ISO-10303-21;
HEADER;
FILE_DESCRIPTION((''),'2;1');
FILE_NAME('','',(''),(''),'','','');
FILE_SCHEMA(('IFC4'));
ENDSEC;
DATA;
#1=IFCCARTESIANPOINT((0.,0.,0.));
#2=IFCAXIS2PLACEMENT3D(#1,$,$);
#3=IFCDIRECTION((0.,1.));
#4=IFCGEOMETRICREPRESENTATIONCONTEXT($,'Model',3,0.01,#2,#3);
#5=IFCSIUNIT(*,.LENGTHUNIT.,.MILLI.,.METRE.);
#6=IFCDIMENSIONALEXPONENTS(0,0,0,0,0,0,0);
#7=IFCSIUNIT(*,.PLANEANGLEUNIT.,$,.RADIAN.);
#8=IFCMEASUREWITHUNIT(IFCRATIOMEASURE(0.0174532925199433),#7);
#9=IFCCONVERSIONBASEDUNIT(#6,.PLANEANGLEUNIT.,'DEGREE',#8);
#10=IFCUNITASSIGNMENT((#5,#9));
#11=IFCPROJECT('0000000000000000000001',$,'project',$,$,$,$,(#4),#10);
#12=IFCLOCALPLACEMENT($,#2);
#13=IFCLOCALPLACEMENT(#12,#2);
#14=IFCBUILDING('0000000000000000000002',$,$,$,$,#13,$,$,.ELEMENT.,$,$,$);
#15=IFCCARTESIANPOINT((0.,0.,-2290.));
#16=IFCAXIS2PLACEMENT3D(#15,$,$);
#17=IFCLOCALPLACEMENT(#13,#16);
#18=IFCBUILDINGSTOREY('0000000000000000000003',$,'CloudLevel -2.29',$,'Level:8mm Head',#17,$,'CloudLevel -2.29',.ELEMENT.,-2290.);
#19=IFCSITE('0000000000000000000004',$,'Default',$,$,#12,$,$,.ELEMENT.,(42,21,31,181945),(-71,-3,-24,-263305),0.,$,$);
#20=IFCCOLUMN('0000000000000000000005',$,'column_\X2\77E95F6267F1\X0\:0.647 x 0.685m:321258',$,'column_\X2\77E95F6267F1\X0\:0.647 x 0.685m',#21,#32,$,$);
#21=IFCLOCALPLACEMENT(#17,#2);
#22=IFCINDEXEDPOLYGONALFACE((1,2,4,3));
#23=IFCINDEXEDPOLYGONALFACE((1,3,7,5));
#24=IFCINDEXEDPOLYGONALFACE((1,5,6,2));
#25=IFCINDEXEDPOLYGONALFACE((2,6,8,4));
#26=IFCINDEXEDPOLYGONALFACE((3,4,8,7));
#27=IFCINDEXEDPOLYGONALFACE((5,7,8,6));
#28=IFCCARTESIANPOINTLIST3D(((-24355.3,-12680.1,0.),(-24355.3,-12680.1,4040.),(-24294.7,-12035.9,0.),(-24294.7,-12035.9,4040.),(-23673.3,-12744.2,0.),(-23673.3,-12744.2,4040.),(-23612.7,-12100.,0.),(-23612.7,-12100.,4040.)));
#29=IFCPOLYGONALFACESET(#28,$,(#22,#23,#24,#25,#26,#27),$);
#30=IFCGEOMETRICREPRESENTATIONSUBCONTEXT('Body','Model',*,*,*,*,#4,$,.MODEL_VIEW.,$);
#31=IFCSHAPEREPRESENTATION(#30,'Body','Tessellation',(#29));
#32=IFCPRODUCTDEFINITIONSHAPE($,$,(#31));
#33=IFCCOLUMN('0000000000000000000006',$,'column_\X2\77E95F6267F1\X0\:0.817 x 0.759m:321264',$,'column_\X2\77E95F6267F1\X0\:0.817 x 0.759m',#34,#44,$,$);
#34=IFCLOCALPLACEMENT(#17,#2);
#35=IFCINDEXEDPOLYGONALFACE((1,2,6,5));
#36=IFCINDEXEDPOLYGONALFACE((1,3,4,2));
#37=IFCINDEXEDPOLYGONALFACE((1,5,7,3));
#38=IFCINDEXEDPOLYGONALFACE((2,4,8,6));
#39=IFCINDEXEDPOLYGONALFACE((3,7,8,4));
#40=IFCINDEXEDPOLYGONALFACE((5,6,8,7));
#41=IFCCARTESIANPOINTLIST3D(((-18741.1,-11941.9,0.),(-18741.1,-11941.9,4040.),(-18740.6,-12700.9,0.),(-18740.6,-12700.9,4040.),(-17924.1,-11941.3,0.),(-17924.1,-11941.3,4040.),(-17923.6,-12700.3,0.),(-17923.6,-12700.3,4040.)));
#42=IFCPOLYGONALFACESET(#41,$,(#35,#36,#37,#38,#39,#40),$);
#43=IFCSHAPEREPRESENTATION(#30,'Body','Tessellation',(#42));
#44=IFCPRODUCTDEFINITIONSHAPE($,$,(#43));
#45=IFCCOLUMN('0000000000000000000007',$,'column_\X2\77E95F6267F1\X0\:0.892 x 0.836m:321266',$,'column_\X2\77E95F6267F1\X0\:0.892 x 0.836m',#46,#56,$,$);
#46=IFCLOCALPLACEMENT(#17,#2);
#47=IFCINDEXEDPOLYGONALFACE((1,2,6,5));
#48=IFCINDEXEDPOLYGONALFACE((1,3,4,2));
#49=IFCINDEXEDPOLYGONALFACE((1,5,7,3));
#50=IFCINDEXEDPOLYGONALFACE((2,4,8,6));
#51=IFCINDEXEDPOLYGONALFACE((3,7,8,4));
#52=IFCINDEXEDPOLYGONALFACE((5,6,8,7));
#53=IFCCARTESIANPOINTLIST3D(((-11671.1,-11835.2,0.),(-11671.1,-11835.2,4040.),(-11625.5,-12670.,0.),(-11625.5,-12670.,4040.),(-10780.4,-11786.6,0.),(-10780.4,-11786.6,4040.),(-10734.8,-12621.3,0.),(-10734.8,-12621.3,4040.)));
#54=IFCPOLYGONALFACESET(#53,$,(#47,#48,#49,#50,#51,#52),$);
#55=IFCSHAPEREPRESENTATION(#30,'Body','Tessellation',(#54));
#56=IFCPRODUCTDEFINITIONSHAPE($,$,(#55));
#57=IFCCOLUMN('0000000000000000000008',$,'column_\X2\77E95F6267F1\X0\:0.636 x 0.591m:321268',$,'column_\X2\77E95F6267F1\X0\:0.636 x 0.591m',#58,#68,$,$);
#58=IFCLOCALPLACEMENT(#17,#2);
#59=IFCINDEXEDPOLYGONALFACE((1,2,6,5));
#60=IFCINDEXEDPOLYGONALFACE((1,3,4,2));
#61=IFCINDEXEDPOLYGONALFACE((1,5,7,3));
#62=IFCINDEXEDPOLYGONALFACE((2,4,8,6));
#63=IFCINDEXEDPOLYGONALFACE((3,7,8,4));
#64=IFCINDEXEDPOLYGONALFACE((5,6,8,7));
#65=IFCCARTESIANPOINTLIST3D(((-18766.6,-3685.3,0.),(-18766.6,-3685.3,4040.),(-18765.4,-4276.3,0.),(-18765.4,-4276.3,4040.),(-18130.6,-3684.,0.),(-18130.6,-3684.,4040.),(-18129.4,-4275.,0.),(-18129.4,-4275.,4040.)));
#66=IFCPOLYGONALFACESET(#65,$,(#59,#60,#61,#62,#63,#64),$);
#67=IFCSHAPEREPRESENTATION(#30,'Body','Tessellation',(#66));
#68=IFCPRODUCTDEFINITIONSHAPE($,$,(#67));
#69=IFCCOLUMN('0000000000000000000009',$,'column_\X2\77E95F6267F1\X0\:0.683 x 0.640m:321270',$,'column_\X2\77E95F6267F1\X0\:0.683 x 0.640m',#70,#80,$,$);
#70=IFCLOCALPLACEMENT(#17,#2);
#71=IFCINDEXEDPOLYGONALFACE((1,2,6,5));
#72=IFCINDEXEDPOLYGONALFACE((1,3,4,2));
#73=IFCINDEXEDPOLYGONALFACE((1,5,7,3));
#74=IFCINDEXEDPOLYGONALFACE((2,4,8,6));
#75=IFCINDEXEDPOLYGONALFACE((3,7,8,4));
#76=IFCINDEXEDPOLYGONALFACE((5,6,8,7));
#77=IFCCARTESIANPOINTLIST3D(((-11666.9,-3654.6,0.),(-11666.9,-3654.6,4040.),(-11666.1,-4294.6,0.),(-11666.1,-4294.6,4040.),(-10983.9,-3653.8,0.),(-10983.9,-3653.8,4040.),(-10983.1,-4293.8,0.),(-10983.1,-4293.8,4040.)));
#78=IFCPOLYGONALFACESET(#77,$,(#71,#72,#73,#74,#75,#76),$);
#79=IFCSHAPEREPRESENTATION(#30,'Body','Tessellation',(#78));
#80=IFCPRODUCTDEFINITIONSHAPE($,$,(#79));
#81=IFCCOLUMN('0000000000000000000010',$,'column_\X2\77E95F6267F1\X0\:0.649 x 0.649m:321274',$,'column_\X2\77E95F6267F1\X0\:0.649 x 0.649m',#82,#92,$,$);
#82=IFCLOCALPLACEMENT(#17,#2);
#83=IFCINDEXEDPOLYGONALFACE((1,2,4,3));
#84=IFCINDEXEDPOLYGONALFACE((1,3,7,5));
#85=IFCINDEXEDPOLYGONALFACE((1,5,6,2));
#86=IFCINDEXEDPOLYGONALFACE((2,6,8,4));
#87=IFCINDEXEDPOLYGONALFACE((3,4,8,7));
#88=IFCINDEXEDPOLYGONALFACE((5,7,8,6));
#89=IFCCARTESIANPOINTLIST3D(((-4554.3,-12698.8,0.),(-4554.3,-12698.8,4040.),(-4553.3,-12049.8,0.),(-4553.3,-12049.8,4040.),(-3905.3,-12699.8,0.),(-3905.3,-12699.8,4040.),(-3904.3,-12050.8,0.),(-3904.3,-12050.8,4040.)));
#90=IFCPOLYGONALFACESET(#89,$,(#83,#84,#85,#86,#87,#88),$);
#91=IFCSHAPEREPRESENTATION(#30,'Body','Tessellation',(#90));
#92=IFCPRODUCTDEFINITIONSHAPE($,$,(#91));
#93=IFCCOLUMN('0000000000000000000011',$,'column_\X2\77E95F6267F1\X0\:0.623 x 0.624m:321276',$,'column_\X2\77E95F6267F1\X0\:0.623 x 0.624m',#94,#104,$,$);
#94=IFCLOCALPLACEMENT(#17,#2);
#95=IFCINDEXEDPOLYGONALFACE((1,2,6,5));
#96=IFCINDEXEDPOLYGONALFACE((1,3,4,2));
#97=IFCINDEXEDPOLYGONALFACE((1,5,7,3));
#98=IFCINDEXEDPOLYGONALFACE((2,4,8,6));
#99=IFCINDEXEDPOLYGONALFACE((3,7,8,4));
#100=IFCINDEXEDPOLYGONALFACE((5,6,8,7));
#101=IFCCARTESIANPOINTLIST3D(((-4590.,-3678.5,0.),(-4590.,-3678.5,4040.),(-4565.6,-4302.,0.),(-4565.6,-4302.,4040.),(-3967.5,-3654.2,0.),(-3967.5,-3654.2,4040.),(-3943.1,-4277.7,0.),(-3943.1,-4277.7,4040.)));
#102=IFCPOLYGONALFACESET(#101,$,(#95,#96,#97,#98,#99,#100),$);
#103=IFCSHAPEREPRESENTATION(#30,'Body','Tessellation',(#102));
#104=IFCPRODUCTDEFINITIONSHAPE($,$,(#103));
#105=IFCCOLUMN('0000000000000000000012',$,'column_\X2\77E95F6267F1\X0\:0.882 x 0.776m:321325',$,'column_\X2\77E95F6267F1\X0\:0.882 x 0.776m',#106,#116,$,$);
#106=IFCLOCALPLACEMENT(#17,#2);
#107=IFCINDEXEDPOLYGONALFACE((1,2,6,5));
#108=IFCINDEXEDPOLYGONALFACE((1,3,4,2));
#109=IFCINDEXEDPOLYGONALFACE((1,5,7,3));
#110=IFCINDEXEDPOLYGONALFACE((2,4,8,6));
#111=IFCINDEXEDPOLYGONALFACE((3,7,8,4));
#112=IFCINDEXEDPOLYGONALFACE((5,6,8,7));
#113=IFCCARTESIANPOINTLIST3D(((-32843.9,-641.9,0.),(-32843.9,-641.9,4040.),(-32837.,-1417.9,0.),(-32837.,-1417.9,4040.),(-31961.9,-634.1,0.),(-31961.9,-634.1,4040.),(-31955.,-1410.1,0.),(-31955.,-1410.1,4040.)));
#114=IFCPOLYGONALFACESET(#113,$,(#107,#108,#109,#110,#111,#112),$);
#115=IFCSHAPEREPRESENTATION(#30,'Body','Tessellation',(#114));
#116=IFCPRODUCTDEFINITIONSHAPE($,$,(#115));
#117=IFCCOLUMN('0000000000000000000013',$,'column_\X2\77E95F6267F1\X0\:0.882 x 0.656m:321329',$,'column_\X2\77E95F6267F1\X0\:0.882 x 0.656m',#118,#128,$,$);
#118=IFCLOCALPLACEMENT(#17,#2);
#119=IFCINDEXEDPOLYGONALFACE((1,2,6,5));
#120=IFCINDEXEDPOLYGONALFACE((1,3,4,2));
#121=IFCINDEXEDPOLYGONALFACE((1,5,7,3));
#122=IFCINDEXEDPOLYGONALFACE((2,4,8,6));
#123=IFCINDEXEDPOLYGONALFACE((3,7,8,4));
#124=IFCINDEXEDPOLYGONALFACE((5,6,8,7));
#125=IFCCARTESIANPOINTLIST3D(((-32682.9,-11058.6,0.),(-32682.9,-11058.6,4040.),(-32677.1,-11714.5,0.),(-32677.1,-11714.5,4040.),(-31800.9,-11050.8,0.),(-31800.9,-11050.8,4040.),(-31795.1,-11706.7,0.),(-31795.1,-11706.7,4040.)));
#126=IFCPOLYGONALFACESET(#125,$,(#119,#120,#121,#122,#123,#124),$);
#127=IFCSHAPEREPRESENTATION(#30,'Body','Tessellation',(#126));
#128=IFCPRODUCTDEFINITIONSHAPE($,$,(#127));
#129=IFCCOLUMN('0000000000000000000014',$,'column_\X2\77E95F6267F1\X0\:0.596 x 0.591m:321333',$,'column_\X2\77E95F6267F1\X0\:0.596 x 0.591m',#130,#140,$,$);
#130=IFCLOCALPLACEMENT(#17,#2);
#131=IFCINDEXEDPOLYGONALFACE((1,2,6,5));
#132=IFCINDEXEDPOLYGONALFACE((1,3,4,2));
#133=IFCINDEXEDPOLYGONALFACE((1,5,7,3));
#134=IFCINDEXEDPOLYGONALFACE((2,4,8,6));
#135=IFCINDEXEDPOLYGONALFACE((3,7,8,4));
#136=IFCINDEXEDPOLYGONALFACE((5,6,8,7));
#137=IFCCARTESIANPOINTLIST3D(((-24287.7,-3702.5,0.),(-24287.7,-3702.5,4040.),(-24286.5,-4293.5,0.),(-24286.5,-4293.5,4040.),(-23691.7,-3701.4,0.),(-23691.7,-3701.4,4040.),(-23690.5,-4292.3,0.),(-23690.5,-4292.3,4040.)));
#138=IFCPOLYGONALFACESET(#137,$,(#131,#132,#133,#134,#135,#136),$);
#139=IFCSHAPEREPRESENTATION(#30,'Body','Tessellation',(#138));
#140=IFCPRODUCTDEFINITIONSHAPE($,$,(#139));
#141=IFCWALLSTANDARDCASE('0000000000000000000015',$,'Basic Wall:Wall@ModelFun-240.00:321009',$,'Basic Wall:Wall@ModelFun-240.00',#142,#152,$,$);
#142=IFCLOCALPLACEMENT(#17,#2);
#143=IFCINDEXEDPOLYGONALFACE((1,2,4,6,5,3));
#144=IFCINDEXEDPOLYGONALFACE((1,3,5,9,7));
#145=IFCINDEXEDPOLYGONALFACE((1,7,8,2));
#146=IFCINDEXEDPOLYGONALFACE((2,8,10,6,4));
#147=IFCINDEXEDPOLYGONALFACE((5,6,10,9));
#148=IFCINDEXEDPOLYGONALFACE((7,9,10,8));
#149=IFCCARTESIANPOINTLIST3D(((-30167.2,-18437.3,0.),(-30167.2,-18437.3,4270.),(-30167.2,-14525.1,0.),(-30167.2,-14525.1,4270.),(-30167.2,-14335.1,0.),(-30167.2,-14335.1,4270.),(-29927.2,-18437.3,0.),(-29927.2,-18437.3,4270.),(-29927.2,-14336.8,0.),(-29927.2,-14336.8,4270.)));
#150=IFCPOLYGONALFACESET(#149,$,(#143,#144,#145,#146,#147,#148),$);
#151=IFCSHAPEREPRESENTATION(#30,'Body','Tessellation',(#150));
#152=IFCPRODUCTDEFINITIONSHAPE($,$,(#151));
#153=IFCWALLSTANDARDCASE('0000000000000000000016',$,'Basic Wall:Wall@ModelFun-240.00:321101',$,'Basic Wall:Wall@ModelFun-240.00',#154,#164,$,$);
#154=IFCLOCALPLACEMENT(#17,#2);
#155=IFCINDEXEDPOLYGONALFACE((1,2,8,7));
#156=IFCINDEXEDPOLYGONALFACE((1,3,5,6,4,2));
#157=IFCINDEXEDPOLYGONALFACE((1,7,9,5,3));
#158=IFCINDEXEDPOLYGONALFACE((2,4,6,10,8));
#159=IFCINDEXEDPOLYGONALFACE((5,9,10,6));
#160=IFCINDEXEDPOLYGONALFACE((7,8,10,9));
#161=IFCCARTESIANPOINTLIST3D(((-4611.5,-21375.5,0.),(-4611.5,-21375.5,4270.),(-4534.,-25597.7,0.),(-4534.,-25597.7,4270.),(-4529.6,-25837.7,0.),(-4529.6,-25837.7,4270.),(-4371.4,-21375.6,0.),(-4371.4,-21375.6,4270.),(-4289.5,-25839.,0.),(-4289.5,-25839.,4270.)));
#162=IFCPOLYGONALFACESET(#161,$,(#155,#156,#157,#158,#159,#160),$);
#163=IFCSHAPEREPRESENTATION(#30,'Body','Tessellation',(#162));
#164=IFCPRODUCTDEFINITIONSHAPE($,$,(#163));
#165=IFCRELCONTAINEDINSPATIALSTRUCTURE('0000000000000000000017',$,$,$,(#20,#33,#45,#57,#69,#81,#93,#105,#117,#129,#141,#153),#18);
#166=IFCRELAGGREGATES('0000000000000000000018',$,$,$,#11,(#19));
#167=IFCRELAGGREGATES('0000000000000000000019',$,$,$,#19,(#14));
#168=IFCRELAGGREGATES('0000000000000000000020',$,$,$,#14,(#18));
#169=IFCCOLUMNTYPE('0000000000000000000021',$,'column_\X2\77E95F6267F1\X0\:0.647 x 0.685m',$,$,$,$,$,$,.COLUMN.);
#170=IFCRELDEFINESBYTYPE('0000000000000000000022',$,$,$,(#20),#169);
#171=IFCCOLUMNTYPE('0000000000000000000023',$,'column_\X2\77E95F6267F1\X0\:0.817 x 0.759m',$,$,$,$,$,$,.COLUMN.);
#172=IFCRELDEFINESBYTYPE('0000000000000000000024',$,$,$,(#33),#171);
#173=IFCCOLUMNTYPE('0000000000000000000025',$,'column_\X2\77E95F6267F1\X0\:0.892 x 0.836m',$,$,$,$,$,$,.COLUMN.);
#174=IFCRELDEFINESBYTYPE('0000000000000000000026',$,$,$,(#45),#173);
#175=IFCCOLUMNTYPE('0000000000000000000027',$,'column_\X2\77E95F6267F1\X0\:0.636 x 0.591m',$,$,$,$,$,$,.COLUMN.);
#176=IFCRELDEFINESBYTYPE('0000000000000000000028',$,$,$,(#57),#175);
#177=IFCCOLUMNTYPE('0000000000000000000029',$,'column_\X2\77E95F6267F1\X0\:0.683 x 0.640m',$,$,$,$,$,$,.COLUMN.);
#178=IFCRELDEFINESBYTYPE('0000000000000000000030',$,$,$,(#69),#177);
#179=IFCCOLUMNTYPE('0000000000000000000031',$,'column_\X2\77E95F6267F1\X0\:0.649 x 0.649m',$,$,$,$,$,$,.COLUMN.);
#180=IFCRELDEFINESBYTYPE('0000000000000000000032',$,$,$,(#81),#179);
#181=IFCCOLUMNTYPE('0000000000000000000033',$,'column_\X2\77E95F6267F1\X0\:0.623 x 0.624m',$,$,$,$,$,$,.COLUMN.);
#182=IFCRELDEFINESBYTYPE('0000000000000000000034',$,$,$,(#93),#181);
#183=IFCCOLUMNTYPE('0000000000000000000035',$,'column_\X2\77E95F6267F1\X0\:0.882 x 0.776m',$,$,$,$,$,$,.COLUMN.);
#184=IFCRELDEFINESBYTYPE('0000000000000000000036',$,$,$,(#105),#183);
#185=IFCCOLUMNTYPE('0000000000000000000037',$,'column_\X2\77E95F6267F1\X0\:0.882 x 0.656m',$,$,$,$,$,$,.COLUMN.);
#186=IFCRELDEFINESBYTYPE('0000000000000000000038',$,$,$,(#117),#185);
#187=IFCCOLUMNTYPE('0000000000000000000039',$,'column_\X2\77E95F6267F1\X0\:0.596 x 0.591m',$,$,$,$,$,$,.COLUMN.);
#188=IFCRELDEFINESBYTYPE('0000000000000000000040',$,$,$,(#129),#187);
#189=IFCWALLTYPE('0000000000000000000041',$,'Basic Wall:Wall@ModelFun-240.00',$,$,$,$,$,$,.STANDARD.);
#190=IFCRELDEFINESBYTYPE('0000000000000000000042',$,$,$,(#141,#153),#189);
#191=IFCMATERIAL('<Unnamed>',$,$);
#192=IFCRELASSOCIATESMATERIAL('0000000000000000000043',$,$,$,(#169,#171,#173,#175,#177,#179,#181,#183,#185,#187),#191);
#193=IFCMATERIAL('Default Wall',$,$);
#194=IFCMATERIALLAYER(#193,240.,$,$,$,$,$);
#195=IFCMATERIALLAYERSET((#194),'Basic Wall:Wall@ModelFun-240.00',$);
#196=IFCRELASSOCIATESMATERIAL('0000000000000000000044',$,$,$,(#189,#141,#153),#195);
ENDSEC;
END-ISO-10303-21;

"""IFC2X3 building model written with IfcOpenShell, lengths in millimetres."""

from ifc_helpers import new_model, entity, si_unit, converted_unit, direction, frame, origin, origin_2d_with_axis, place, context, subcontext, project, spatial, polyline, rectangle, outline, extrude, source, transform, mapped, material, layer, layer_set, layer_usage, type_object, type_shapes, element, save


model = new_model("IFC2X3")

# Units and contexts
model_context = context("Model", 3, precision=0.01, world=origin(), true_north=direction((0.0, 1.0)))
body_context = subcontext(model_context, "Body", "Model", "MODEL_VIEW")
ifc_project = project(units=[si_unit("LENGTHUNIT", "METRE", prefix="MILLI"), converted_unit("PLANEANGLEUNIT", "DEGREE", entity("IfcRatioMeasure", 0.0174532925199433), si_unit("PLANEANGLEUNIT", "RADIAN"), dimensions=[0, 0, 0, 0, 0, 0, 0])], contexts=[model_context])

# Site, building, storey
site_placement = place(None, origin())
site = spatial("IfcSite", under=ifc_project, at=site_placement, Name="Default", CompositionType="ELEMENT", RefLatitude=(42, 21, 31, 181945), RefLongitude=(-71, -3, -24, -263305), RefElevation=0.0)
building_placement = place(site_placement, origin())
building = spatial("IfcBuilding", under=site, at=building_placement, CompositionType="ELEMENT")
storey_placement = place(building_placement, frame((0.0, 0.0, -2290.0)))
storey = spatial("IfcBuildingStorey", under=building, at=storey_placement, Name="CloudLevel -2.29", ObjectType="Level:8mm Head", LongName="CloudLevel -2.29", CompositionType="ELEMENT", Elevation=-2290.0)

# Columns
ifc_material_1 = material(Name="<Unnamed>")
ifc_material_2 = material(Name="Default Wall")
column_type_1 = type_object("IfcColumnType", Name="column_矩形柱:0.647 x 0.685m", PredefinedType="COLUMN", material=ifc_material_1)
shared_shape_1 = source(origin(), body_context, "Body", "SweptSolid", [
    extrude(rectangle(XDim=685.0, YDim=647.0, at=origin_2d_with_axis()), frame((0.0, 0.0, -2290.0), z_axis=(0.0, 0.0, 1.0), x_axis=(0.0, -1.0, 0.0)), (0.0, 0.0, 1.0), 4040.0),
])
type_shapes(column_type_1, [shared_shape_1])
column_1_placement = place(storey_placement, frame((-23984.0, -12390.1, 2290.0), z_axis=(0.0, 0.0, 1.0), x_axis=(0.093573, 0.995612, 0.0)))
element("IfcColumn", 1, at=column_1_placement, inside=storey, type_object=column_type_1, Name="column_矩形柱:0.647 x 0.685m:321258", ObjectType="column_矩形柱:0.647 x 0.685m", context=body_context, shape_type="MappedRepresentation", body=[
    mapped(shared_shape_1, transform((0.0, 0.0, 0.0), scale=1.0)),
])
column_type_2 = type_object("IfcColumnType", Name="column_矩形柱:0.817 x 0.759m", PredefinedType="COLUMN", material=ifc_material_1)
shared_shape_2 = source(origin(), body_context, "Body", "SweptSolid", [
    extrude(rectangle(XDim=759.0, YDim=817.0, at=origin_2d_with_axis()), frame((0.0, 0.0, -2290.0), z_axis=(0.0, 0.0, 1.0), x_axis=(0.0, -1.0, 0.0)), (0.0, 0.0, 1.0), 4040.0),
])
type_shapes(column_type_2, [shared_shape_2])
column_2_placement = place(storey_placement, frame((-18332.4, -12321.1, 2290.0), z_axis=(0.0, 0.0, 1.0), x_axis=(1.0, 0.000748, 0.0)))
element("IfcColumn", 2, at=column_2_placement, inside=storey, type_object=column_type_2, Name="column_矩形柱:0.817 x 0.759m:321264", ObjectType="column_矩形柱:0.817 x 0.759m", context=body_context, shape_type="MappedRepresentation", body=[
    mapped(shared_shape_2, transform((0.0, 0.0, 0.0), scale=1.0)),
])
column_type_3 = type_object("IfcColumnType", Name="column_矩形柱:0.892 x 0.836m", PredefinedType="COLUMN", material=ifc_material_1)
shared_shape_3 = source(origin(), body_context, "Body", "SweptSolid", [
    extrude(rectangle(XDim=836.0, YDim=892.0, at=origin_2d_with_axis()), frame((0.0, 0.0, -2290.0), z_axis=(0.0, 0.0, 1.0), x_axis=(0.0, -1.0, 0.0)), (0.0, 0.0, 1.0), 4040.0),
])
type_shapes(column_type_3, [shared_shape_3])
column_3_placement = place(storey_placement, frame((-11202.9, -12228.3, 2290.0), z_axis=(0.0, 0.0, 1.0), x_axis=(0.998512, 0.054528, 0.0)))
element("IfcColumn", 3, at=column_3_placement, inside=storey, type_object=column_type_3, Name="column_矩形柱:0.892 x 0.836m:321266", ObjectType="column_矩形柱:0.892 x 0.836m", context=body_context, shape_type="MappedRepresentation", body=[
    mapped(shared_shape_3, transform((0.0, 0.0, 0.0), scale=1.0)),
])
column_type_4 = type_object("IfcColumnType", Name="column_矩形柱:0.636 x 0.591m", PredefinedType="COLUMN", material=ifc_material_1)
shared_shape_4 = source(origin(), body_context, "Body", "SweptSolid", [
    extrude(rectangle(XDim=591.0, YDim=636.0, at=origin_2d_with_axis()), frame((0.0, 0.0, -2290.0), z_axis=(0.0, 0.0, 1.0), x_axis=(0.0, -1.0, 0.0)), (0.0, 0.0, 1.0), 4040.0),
])
type_shapes(column_type_4, [shared_shape_4])
column_4_placement = place(storey_placement, frame((-18448.0, -3980.1, 2290.0), z_axis=(0.0, 0.0, 1.0), x_axis=(0.999998, 0.002007, 0.0)))
element("IfcColumn", 4, at=column_4_placement, inside=storey, type_object=column_type_4, Name="column_矩形柱:0.636 x 0.591m:321268", ObjectType="column_矩形柱:0.636 x 0.591m", context=body_context, shape_type="MappedRepresentation", body=[
    mapped(shared_shape_4, transform((0.0, 0.0, 0.0), scale=1.0)),
])
column_type_5 = type_object("IfcColumnType", Name="column_矩形柱:0.683 x 0.640m", PredefinedType="COLUMN", material=ifc_material_1)
shared_shape_5 = source(origin(), body_context, "Body", "SweptSolid", [
    extrude(rectangle(XDim=640.0, YDim=683.0, at=origin_2d_with_axis()), frame((0.0, 0.0, -2290.0), z_axis=(0.0, 0.0, 1.0), x_axis=(0.0, -1.0, 0.0)), (0.0, 0.0, 1.0), 4040.0),
])
type_shapes(column_type_5, [shared_shape_5])
column_5_placement = place(storey_placement, frame((-11325.0, -3974.2, 2290.0), z_axis=(0.0, 0.0, 1.0), x_axis=(0.999999, 0.001245, 0.0)))
element("IfcColumn", 5, at=column_5_placement, inside=storey, type_object=column_type_5, Name="column_矩形柱:0.683 x 0.640m:321270", ObjectType="column_矩形柱:0.683 x 0.640m", context=body_context, shape_type="MappedRepresentation", body=[
    mapped(shared_shape_5, transform((0.0, 0.0, 0.0), scale=1.0)),
])
column_type_6 = type_object("IfcColumnType", Name="column_矩形柱:0.649 x 0.649m", PredefinedType="COLUMN", material=ifc_material_1)
shared_shape_6 = source(origin(), body_context, "Body", "SweptSolid", [
    extrude(rectangle(XDim=649.0, YDim=649.0, at=origin_2d_with_axis()), frame((0.0, 0.0, -2290.0), z_axis=(0.0, 0.0, 1.0), x_axis=(0.0, -1.0, 0.0)), (0.0, 0.0, 1.0), 4040.0),
])
type_shapes(column_type_6, [shared_shape_6])
column_6_placement = place(storey_placement, frame((-4229.3, -12374.8, 2290.0), z_axis=(0.0, 0.0, 1.0), x_axis=(0.001505, 0.999999, 0.0)))
element("IfcColumn", 6, at=column_6_placement, inside=storey, type_object=column_type_6, Name="column_矩形柱:0.649 x 0.649m:321274", ObjectType="column_矩形柱:0.649 x 0.649m", context=body_context, shape_type="MappedRepresentation", body=[
    mapped(shared_shape_6, transform((0.0, 0.0, 0.0), scale=1.0)),
])
column_type_7 = type_object("IfcColumnType", Name="column_矩形柱:0.623 x 0.624m", PredefinedType="COLUMN", material=ifc_material_1)
shared_shape_7 = source(origin(), body_context, "Body", "SweptSolid", [
    extrude(rectangle(XDim=624.0, YDim=623.0, at=origin_2d_with_axis()), frame((0.0, 0.0, -2290.0), z_axis=(0.0, 0.0, 1.0), x_axis=(0.0, -1.0, 0.0)), (0.0, 0.0, 1.0), 4040.0),
])
type_shapes(column_type_7, [shared_shape_7])
column_7_placement = place(storey_placement, frame((-4266.6, -3978.1, 2290.0), z_axis=(0.0, 0.0, 1.0), x_axis=(0.999237, 0.039057, 0.0)))
element("IfcColumn", 7, at=column_7_placement, inside=storey, type_object=column_type_7, Name="column_矩形柱:0.623 x 0.624m:321276", ObjectType="column_矩形柱:0.623 x 0.624m", context=body_context, shape_type="MappedRepresentation", body=[
    mapped(shared_shape_7, transform((0.0, 0.0, 0.0), scale=1.0)),
])
column_type_8 = type_object("IfcColumnType", Name="column_矩形柱:0.882 x 0.776m", PredefinedType="COLUMN", material=ifc_material_1)
shared_shape_8 = source(origin(), body_context, "Body", "SweptSolid", [
    extrude(rectangle(XDim=776.0, YDim=882.0, at=origin_2d_with_axis()), frame((0.0, 0.0, -2290.0), z_axis=(0.0, 0.0, 1.0), x_axis=(0.0, -1.0, 0.0)), (0.0, 0.0, 1.0), 4040.0),
])
type_shapes(column_type_8, [shared_shape_8])
column_8_placement = place(storey_placement, frame((-32399.4, -1026.0, 2290.0), z_axis=(0.0, 0.0, 1.0), x_axis=(0.999961, 0.008846, 0.0)))
element("IfcColumn", 8, at=column_8_placement, inside=storey, type_object=column_type_8, Name="column_矩形柱:0.882 x 0.776m:321325", ObjectType="column_矩形柱:0.882 x 0.776m", context=body_context, shape_type="MappedRepresentation", body=[
    mapped(shared_shape_8, transform((0.0, 0.0, 0.0), scale=1.0)),
])
column_type_9 = type_object("IfcColumnType", Name="column_矩形柱:0.882 x 0.656m", PredefinedType="COLUMN", material=ifc_material_1)
shared_shape_9 = source(origin(), body_context, "Body", "SweptSolid", [
    extrude(rectangle(XDim=656.0, YDim=882.0, at=origin_2d_with_axis()), frame((0.0, 0.0, -2290.0), z_axis=(0.0, 0.0, 1.0), x_axis=(0.0, -1.0, 0.0)), (0.0, 0.0, 1.0), 4040.0),
])
type_shapes(column_type_9, [shared_shape_9])
column_9_placement = place(storey_placement, frame((-32239.0, -11382.6, 2290.0), z_axis=(0.0, 0.0, 1.0), x_axis=(0.999961, 0.008846, 0.0)))
element("IfcColumn", 9, at=column_9_placement, inside=storey, type_object=column_type_9, Name="column_矩形柱:0.882 x 0.656m:321329", ObjectType="column_矩形柱:0.882 x 0.656m", context=body_context, shape_type="MappedRepresentation", body=[
    mapped(shared_shape_9, transform((0.0, 0.0, 0.0), scale=1.0)),
])
column_type_10 = type_object("IfcColumnType", Name="column_矩形柱:0.596 x 0.591m", PredefinedType="COLUMN", material=ifc_material_1)
shared_shape_10 = source(origin(), body_context, "Body", "SweptSolid", [
    extrude(rectangle(XDim=591.0, YDim=596.0, at=origin_2d_with_axis()), frame((0.0, 0.0, -2290.0), z_axis=(0.0, 0.0, 1.0), x_axis=(0.0, -1.0, 0.0)), (0.0, 0.0, 1.0), 4040.0),
])
type_shapes(column_type_10, [shared_shape_10])
column_10_placement = place(storey_placement, frame((-23989.1, -3997.4, 2290.0), z_axis=(0.0, 0.0, 1.0), x_axis=(0.999998, 0.002007, 0.0)))
element("IfcColumn", 10, at=column_10_placement, inside=storey, type_object=column_type_10, Name="column_矩形柱:0.596 x 0.591m:321333", ObjectType="column_矩形柱:0.596 x 0.591m", context=body_context, shape_type="MappedRepresentation", body=[
    mapped(shared_shape_10, transform((0.0, 0.0, 0.0), scale=1.0)),
])

# Walls
ifc_layer_1 = layer(ifc_material_2, 240.0)
ifc_layer_set_1 = layer_set([ifc_layer_1], Name="Basic Wall:Wall@ModelFun-240.00")
ifc_layer_usage_1 = layer_usage(ifc_layer_set_1, "AXIS2", "NEGATIVE", 120.0)
wall_type_1 = type_object("IfcWallType", Name="Basic Wall:Wall@ModelFun-240.00", PredefinedType="STANDARD", material=ifc_layer_set_1)
wall_1_placement = place(storey_placement, frame((-30047.2, -14335.1, 0.0), z_axis=(0.0, 0.0, 1.0), x_axis=(0.0, -1.0, 0.0)))
element("IfcWallStandardCase", 11, at=wall_1_placement, inside=storey, type_object=wall_type_1, material=ifc_layer_usage_1, Name="Basic Wall:Wall@ModelFun-240.00:321009", ObjectType="Basic Wall:Wall@ModelFun-240.00", context=body_context, shape_type="SweptSolid", body=[
    extrude(outline(polyline([(4102.2, -120.0), (4102.2, 120.0), (1.7, 120.0), (0.0, -120.0), (190.0, -120.0), (4102.2, -120.0)])), origin(), (0.0, 0.0, 1.0), 4270.0),
])
ifc_layer_usage_2 = layer_usage(ifc_layer_set_1, "AXIS2", "NEGATIVE", 120.0)
wall_2_placement = place(storey_placement, frame((-4491.5, -21373.3, 0.0), z_axis=(0.0, 0.0, 1.0), x_axis=(0.018349, -0.999832, 0.0)))
element("IfcWallStandardCase", 12, at=wall_2_placement, inside=storey, type_object=wall_type_1, material=ifc_layer_usage_2, Name="Basic Wall:Wall@ModelFun-240.00:321101", ObjectType="Basic Wall:Wall@ModelFun-240.00", context=body_context, shape_type="SweptSolid", body=[
    extrude(outline(polyline([(4462.9, -120.0), (4468.7, 120.0), (4.5, 120.0), (0.0, -120.0), (4222.8, -120.0), (4462.9, -120.0)])), origin(), (0.0, 0.0, 1.0), 4270.0),
])

save(model, "model.ifc")
